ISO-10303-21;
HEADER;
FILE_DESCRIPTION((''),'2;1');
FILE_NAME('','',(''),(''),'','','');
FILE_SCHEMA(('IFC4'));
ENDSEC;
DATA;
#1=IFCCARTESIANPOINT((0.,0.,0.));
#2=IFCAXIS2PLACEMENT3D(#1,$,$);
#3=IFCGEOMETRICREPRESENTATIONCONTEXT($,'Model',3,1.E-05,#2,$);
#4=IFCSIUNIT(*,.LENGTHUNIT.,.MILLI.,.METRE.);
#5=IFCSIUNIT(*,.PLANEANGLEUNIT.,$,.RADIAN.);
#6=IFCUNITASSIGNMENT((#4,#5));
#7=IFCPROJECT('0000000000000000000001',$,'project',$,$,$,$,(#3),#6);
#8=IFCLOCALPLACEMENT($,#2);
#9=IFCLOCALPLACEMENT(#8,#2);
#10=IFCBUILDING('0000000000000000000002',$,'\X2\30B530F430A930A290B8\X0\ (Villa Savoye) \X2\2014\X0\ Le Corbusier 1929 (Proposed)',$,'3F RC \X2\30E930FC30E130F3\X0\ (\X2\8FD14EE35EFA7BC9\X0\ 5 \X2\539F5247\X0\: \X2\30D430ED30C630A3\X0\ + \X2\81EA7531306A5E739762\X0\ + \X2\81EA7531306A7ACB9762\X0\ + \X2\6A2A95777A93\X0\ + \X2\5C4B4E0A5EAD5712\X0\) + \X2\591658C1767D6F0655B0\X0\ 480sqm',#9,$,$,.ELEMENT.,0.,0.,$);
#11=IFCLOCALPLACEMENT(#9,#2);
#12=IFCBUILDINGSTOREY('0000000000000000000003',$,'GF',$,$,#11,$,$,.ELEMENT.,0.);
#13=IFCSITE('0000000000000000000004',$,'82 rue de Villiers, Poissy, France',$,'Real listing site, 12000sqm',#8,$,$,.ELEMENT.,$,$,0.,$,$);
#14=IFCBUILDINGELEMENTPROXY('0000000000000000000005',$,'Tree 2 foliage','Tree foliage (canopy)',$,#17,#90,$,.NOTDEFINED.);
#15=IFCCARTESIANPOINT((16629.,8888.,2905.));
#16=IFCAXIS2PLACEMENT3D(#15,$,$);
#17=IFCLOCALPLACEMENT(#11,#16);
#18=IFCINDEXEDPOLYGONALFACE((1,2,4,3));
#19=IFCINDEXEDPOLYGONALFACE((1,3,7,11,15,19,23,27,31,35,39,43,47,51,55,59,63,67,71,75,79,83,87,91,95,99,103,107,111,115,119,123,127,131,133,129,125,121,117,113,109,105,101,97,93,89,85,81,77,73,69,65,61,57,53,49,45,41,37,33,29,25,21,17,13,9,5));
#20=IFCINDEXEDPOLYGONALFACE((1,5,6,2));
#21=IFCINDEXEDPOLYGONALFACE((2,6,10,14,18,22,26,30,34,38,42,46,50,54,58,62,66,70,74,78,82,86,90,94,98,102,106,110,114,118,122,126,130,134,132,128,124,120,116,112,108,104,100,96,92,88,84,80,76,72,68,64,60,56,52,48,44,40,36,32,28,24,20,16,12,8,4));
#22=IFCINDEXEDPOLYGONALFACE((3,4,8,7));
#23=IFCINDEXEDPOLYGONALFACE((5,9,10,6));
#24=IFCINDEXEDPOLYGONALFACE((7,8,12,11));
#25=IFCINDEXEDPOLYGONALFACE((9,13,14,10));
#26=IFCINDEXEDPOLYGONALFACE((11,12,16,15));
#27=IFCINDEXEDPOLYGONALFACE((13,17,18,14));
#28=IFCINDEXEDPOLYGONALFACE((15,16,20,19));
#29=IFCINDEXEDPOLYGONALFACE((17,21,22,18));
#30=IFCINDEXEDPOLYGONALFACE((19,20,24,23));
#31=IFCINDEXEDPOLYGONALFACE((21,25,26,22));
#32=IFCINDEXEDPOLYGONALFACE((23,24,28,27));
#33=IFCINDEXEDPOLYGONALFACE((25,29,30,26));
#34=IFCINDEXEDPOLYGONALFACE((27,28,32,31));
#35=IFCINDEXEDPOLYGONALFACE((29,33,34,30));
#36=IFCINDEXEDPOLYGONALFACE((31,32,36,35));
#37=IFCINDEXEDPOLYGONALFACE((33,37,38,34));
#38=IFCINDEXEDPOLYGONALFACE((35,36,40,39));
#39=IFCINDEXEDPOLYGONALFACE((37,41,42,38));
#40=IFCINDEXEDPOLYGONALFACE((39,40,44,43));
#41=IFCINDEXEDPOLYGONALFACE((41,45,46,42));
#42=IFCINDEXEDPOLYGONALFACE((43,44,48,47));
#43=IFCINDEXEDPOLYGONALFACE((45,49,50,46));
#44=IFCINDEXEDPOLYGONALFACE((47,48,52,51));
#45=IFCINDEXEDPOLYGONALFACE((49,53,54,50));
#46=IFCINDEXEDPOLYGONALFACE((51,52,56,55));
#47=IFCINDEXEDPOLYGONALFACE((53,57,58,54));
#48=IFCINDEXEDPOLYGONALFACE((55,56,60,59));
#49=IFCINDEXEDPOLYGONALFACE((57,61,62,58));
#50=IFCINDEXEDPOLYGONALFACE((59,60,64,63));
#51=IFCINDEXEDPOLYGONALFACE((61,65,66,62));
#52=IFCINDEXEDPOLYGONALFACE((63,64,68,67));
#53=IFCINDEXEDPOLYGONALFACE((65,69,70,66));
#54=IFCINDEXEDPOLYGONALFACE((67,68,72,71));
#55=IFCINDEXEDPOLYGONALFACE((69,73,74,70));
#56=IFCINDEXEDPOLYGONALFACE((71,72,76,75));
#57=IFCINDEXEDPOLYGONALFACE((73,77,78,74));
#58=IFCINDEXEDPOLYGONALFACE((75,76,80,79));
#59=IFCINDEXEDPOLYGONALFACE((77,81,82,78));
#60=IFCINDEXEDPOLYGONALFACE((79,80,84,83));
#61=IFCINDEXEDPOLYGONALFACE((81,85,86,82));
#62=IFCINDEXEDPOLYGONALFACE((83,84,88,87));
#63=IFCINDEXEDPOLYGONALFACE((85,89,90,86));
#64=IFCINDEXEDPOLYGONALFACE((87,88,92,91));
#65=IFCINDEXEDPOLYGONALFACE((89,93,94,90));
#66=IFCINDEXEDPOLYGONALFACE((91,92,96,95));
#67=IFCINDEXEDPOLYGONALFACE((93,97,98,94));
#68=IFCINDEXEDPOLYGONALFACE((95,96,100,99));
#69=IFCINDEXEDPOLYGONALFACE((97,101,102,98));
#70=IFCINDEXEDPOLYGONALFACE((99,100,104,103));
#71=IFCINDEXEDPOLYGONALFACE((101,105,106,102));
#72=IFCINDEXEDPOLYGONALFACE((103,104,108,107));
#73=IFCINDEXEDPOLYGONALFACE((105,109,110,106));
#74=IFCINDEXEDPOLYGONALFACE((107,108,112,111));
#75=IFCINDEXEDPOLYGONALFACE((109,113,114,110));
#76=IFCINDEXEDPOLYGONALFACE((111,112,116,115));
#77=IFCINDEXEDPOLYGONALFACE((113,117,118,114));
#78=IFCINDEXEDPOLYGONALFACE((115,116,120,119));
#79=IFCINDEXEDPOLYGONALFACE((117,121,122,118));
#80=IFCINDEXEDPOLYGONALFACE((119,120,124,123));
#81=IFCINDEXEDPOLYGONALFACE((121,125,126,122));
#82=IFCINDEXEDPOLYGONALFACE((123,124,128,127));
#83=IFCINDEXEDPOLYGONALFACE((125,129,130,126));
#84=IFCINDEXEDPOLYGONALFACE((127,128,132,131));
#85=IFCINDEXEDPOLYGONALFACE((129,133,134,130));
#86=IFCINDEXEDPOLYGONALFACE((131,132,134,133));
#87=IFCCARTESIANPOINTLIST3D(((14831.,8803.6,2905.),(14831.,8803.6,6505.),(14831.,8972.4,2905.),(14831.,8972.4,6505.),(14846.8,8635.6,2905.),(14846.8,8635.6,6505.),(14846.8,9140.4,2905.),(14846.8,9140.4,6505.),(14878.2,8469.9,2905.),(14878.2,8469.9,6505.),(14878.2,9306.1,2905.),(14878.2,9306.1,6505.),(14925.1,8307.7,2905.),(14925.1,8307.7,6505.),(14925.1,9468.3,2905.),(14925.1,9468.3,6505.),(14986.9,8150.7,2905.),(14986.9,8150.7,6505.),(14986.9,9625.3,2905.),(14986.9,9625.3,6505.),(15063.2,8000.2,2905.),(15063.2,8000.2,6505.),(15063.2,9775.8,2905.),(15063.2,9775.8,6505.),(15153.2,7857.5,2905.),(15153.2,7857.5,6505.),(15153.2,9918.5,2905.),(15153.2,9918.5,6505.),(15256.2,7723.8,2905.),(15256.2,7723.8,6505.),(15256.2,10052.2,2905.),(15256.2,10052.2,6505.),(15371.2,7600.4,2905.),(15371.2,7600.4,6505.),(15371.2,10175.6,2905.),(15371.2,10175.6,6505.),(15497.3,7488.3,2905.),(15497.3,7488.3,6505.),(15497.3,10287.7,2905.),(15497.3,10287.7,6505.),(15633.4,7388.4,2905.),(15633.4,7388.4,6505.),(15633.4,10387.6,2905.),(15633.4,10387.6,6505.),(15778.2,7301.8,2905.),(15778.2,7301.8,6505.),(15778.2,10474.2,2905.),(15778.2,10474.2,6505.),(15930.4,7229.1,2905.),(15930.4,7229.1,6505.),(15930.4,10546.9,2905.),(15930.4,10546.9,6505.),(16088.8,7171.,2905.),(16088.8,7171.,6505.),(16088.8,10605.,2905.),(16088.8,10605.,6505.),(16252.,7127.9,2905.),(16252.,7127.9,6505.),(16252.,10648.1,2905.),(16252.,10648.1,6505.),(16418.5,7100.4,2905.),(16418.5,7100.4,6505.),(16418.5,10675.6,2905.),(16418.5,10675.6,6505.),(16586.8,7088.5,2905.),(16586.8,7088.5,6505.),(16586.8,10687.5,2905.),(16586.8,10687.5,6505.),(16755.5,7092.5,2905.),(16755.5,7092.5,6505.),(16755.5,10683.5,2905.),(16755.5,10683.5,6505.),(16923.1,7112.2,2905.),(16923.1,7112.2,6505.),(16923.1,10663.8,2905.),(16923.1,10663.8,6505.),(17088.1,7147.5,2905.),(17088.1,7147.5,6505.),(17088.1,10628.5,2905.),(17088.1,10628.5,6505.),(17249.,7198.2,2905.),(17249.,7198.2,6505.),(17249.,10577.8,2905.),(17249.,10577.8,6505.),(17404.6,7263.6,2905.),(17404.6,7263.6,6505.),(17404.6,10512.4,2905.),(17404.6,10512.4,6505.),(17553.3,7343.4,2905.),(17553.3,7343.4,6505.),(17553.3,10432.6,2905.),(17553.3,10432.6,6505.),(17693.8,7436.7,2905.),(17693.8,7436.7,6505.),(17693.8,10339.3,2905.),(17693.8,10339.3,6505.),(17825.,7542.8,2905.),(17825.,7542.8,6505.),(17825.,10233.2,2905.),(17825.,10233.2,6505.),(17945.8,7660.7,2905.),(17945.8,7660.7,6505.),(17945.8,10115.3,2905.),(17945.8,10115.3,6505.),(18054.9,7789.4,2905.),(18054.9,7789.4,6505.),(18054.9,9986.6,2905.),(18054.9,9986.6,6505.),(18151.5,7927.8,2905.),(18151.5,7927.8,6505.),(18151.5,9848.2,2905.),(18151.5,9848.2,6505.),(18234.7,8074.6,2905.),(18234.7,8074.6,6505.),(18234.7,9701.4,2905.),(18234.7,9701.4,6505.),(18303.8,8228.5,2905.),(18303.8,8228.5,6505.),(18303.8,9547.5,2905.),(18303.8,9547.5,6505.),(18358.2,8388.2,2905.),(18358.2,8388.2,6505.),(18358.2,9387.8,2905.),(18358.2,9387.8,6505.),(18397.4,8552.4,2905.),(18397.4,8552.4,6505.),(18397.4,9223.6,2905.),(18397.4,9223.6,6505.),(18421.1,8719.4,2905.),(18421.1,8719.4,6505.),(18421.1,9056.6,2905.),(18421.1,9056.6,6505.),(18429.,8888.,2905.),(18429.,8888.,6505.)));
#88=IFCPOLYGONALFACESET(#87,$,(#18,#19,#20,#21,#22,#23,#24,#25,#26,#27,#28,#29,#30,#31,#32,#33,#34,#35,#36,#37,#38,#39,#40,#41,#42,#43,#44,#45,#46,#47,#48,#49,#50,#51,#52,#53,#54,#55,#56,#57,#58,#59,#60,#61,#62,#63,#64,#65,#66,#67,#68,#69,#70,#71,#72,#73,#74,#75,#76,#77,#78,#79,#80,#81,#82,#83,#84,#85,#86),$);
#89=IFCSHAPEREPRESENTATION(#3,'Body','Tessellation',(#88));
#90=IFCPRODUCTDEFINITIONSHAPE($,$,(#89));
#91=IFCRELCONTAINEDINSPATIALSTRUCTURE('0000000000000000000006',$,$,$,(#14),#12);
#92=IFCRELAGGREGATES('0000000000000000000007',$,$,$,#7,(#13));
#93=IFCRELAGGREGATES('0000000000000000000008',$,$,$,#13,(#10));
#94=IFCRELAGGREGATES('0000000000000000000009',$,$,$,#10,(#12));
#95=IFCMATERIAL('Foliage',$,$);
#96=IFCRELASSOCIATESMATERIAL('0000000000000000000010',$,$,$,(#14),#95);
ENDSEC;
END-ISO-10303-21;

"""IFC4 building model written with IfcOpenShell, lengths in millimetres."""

from ifc_helpers import new_model, si_unit, frame, origin, origin_2d, place, context, project, spatial, circle, extrude, material, element, save


model = new_model("IFC4")

# Units and contexts
model_context = context("Model", 3, precision=1e-05, world=origin())
ifc_project = project(units=[si_unit("LENGTHUNIT", "METRE", prefix="MILLI"), si_unit("PLANEANGLEUNIT", "RADIAN")], contexts=[model_context])

# Site, building, storey
site_placement = place(None, origin())
site = spatial("IfcSite", under=ifc_project, at=site_placement, Name="82 rue de Villiers, Poissy, France", ObjectType="Real listing site, 12000sqm", CompositionType="ELEMENT", RefElevation=0.0)
building_placement = place(site_placement, origin())
building = spatial("IfcBuilding", under=site, at=building_placement, Name="サヴォア邸 (Villa Savoye) — Le Corbusier 1929 (Proposed)", ObjectType="3F RC ラーメン (近代建築 5 原則: ピロティ + 自由な平面 + 自由な立面 + 横長窓 + 屋上庭園) + 外壁白漆喰 480sqm", CompositionType="ELEMENT", ElevationOfRefHeight=0.0, ElevationOfTerrain=0.0)
storey_placement = place(building_placement, origin())
storey = spatial("IfcBuildingStorey", under=building, at=storey_placement, Name="GF", CompositionType="ELEMENT", Elevation=0.0)

# Building element proxy
ifc_material_1 = material(Name="Foliage")
proxy_1_placement = place(storey_placement, frame((16629.0, 8888.0, 2905.0)))
element("IfcBuildingElementProxy", 1, at=proxy_1_placement, inside=storey, material=ifc_material_1, Name="Tree 2 foliage", Description="Tree foliage (canopy)", PredefinedType="NOTDEFINED", context=model_context, shape_type="SweptSolid", body=[
    extrude(circle(Radius=1800.0, at=origin_2d()), frame((16629.0, 8888.0, 2905.0)), (0.0, 0.0, 1.0), 3600.0),
])

save(model, "model.ifc")
